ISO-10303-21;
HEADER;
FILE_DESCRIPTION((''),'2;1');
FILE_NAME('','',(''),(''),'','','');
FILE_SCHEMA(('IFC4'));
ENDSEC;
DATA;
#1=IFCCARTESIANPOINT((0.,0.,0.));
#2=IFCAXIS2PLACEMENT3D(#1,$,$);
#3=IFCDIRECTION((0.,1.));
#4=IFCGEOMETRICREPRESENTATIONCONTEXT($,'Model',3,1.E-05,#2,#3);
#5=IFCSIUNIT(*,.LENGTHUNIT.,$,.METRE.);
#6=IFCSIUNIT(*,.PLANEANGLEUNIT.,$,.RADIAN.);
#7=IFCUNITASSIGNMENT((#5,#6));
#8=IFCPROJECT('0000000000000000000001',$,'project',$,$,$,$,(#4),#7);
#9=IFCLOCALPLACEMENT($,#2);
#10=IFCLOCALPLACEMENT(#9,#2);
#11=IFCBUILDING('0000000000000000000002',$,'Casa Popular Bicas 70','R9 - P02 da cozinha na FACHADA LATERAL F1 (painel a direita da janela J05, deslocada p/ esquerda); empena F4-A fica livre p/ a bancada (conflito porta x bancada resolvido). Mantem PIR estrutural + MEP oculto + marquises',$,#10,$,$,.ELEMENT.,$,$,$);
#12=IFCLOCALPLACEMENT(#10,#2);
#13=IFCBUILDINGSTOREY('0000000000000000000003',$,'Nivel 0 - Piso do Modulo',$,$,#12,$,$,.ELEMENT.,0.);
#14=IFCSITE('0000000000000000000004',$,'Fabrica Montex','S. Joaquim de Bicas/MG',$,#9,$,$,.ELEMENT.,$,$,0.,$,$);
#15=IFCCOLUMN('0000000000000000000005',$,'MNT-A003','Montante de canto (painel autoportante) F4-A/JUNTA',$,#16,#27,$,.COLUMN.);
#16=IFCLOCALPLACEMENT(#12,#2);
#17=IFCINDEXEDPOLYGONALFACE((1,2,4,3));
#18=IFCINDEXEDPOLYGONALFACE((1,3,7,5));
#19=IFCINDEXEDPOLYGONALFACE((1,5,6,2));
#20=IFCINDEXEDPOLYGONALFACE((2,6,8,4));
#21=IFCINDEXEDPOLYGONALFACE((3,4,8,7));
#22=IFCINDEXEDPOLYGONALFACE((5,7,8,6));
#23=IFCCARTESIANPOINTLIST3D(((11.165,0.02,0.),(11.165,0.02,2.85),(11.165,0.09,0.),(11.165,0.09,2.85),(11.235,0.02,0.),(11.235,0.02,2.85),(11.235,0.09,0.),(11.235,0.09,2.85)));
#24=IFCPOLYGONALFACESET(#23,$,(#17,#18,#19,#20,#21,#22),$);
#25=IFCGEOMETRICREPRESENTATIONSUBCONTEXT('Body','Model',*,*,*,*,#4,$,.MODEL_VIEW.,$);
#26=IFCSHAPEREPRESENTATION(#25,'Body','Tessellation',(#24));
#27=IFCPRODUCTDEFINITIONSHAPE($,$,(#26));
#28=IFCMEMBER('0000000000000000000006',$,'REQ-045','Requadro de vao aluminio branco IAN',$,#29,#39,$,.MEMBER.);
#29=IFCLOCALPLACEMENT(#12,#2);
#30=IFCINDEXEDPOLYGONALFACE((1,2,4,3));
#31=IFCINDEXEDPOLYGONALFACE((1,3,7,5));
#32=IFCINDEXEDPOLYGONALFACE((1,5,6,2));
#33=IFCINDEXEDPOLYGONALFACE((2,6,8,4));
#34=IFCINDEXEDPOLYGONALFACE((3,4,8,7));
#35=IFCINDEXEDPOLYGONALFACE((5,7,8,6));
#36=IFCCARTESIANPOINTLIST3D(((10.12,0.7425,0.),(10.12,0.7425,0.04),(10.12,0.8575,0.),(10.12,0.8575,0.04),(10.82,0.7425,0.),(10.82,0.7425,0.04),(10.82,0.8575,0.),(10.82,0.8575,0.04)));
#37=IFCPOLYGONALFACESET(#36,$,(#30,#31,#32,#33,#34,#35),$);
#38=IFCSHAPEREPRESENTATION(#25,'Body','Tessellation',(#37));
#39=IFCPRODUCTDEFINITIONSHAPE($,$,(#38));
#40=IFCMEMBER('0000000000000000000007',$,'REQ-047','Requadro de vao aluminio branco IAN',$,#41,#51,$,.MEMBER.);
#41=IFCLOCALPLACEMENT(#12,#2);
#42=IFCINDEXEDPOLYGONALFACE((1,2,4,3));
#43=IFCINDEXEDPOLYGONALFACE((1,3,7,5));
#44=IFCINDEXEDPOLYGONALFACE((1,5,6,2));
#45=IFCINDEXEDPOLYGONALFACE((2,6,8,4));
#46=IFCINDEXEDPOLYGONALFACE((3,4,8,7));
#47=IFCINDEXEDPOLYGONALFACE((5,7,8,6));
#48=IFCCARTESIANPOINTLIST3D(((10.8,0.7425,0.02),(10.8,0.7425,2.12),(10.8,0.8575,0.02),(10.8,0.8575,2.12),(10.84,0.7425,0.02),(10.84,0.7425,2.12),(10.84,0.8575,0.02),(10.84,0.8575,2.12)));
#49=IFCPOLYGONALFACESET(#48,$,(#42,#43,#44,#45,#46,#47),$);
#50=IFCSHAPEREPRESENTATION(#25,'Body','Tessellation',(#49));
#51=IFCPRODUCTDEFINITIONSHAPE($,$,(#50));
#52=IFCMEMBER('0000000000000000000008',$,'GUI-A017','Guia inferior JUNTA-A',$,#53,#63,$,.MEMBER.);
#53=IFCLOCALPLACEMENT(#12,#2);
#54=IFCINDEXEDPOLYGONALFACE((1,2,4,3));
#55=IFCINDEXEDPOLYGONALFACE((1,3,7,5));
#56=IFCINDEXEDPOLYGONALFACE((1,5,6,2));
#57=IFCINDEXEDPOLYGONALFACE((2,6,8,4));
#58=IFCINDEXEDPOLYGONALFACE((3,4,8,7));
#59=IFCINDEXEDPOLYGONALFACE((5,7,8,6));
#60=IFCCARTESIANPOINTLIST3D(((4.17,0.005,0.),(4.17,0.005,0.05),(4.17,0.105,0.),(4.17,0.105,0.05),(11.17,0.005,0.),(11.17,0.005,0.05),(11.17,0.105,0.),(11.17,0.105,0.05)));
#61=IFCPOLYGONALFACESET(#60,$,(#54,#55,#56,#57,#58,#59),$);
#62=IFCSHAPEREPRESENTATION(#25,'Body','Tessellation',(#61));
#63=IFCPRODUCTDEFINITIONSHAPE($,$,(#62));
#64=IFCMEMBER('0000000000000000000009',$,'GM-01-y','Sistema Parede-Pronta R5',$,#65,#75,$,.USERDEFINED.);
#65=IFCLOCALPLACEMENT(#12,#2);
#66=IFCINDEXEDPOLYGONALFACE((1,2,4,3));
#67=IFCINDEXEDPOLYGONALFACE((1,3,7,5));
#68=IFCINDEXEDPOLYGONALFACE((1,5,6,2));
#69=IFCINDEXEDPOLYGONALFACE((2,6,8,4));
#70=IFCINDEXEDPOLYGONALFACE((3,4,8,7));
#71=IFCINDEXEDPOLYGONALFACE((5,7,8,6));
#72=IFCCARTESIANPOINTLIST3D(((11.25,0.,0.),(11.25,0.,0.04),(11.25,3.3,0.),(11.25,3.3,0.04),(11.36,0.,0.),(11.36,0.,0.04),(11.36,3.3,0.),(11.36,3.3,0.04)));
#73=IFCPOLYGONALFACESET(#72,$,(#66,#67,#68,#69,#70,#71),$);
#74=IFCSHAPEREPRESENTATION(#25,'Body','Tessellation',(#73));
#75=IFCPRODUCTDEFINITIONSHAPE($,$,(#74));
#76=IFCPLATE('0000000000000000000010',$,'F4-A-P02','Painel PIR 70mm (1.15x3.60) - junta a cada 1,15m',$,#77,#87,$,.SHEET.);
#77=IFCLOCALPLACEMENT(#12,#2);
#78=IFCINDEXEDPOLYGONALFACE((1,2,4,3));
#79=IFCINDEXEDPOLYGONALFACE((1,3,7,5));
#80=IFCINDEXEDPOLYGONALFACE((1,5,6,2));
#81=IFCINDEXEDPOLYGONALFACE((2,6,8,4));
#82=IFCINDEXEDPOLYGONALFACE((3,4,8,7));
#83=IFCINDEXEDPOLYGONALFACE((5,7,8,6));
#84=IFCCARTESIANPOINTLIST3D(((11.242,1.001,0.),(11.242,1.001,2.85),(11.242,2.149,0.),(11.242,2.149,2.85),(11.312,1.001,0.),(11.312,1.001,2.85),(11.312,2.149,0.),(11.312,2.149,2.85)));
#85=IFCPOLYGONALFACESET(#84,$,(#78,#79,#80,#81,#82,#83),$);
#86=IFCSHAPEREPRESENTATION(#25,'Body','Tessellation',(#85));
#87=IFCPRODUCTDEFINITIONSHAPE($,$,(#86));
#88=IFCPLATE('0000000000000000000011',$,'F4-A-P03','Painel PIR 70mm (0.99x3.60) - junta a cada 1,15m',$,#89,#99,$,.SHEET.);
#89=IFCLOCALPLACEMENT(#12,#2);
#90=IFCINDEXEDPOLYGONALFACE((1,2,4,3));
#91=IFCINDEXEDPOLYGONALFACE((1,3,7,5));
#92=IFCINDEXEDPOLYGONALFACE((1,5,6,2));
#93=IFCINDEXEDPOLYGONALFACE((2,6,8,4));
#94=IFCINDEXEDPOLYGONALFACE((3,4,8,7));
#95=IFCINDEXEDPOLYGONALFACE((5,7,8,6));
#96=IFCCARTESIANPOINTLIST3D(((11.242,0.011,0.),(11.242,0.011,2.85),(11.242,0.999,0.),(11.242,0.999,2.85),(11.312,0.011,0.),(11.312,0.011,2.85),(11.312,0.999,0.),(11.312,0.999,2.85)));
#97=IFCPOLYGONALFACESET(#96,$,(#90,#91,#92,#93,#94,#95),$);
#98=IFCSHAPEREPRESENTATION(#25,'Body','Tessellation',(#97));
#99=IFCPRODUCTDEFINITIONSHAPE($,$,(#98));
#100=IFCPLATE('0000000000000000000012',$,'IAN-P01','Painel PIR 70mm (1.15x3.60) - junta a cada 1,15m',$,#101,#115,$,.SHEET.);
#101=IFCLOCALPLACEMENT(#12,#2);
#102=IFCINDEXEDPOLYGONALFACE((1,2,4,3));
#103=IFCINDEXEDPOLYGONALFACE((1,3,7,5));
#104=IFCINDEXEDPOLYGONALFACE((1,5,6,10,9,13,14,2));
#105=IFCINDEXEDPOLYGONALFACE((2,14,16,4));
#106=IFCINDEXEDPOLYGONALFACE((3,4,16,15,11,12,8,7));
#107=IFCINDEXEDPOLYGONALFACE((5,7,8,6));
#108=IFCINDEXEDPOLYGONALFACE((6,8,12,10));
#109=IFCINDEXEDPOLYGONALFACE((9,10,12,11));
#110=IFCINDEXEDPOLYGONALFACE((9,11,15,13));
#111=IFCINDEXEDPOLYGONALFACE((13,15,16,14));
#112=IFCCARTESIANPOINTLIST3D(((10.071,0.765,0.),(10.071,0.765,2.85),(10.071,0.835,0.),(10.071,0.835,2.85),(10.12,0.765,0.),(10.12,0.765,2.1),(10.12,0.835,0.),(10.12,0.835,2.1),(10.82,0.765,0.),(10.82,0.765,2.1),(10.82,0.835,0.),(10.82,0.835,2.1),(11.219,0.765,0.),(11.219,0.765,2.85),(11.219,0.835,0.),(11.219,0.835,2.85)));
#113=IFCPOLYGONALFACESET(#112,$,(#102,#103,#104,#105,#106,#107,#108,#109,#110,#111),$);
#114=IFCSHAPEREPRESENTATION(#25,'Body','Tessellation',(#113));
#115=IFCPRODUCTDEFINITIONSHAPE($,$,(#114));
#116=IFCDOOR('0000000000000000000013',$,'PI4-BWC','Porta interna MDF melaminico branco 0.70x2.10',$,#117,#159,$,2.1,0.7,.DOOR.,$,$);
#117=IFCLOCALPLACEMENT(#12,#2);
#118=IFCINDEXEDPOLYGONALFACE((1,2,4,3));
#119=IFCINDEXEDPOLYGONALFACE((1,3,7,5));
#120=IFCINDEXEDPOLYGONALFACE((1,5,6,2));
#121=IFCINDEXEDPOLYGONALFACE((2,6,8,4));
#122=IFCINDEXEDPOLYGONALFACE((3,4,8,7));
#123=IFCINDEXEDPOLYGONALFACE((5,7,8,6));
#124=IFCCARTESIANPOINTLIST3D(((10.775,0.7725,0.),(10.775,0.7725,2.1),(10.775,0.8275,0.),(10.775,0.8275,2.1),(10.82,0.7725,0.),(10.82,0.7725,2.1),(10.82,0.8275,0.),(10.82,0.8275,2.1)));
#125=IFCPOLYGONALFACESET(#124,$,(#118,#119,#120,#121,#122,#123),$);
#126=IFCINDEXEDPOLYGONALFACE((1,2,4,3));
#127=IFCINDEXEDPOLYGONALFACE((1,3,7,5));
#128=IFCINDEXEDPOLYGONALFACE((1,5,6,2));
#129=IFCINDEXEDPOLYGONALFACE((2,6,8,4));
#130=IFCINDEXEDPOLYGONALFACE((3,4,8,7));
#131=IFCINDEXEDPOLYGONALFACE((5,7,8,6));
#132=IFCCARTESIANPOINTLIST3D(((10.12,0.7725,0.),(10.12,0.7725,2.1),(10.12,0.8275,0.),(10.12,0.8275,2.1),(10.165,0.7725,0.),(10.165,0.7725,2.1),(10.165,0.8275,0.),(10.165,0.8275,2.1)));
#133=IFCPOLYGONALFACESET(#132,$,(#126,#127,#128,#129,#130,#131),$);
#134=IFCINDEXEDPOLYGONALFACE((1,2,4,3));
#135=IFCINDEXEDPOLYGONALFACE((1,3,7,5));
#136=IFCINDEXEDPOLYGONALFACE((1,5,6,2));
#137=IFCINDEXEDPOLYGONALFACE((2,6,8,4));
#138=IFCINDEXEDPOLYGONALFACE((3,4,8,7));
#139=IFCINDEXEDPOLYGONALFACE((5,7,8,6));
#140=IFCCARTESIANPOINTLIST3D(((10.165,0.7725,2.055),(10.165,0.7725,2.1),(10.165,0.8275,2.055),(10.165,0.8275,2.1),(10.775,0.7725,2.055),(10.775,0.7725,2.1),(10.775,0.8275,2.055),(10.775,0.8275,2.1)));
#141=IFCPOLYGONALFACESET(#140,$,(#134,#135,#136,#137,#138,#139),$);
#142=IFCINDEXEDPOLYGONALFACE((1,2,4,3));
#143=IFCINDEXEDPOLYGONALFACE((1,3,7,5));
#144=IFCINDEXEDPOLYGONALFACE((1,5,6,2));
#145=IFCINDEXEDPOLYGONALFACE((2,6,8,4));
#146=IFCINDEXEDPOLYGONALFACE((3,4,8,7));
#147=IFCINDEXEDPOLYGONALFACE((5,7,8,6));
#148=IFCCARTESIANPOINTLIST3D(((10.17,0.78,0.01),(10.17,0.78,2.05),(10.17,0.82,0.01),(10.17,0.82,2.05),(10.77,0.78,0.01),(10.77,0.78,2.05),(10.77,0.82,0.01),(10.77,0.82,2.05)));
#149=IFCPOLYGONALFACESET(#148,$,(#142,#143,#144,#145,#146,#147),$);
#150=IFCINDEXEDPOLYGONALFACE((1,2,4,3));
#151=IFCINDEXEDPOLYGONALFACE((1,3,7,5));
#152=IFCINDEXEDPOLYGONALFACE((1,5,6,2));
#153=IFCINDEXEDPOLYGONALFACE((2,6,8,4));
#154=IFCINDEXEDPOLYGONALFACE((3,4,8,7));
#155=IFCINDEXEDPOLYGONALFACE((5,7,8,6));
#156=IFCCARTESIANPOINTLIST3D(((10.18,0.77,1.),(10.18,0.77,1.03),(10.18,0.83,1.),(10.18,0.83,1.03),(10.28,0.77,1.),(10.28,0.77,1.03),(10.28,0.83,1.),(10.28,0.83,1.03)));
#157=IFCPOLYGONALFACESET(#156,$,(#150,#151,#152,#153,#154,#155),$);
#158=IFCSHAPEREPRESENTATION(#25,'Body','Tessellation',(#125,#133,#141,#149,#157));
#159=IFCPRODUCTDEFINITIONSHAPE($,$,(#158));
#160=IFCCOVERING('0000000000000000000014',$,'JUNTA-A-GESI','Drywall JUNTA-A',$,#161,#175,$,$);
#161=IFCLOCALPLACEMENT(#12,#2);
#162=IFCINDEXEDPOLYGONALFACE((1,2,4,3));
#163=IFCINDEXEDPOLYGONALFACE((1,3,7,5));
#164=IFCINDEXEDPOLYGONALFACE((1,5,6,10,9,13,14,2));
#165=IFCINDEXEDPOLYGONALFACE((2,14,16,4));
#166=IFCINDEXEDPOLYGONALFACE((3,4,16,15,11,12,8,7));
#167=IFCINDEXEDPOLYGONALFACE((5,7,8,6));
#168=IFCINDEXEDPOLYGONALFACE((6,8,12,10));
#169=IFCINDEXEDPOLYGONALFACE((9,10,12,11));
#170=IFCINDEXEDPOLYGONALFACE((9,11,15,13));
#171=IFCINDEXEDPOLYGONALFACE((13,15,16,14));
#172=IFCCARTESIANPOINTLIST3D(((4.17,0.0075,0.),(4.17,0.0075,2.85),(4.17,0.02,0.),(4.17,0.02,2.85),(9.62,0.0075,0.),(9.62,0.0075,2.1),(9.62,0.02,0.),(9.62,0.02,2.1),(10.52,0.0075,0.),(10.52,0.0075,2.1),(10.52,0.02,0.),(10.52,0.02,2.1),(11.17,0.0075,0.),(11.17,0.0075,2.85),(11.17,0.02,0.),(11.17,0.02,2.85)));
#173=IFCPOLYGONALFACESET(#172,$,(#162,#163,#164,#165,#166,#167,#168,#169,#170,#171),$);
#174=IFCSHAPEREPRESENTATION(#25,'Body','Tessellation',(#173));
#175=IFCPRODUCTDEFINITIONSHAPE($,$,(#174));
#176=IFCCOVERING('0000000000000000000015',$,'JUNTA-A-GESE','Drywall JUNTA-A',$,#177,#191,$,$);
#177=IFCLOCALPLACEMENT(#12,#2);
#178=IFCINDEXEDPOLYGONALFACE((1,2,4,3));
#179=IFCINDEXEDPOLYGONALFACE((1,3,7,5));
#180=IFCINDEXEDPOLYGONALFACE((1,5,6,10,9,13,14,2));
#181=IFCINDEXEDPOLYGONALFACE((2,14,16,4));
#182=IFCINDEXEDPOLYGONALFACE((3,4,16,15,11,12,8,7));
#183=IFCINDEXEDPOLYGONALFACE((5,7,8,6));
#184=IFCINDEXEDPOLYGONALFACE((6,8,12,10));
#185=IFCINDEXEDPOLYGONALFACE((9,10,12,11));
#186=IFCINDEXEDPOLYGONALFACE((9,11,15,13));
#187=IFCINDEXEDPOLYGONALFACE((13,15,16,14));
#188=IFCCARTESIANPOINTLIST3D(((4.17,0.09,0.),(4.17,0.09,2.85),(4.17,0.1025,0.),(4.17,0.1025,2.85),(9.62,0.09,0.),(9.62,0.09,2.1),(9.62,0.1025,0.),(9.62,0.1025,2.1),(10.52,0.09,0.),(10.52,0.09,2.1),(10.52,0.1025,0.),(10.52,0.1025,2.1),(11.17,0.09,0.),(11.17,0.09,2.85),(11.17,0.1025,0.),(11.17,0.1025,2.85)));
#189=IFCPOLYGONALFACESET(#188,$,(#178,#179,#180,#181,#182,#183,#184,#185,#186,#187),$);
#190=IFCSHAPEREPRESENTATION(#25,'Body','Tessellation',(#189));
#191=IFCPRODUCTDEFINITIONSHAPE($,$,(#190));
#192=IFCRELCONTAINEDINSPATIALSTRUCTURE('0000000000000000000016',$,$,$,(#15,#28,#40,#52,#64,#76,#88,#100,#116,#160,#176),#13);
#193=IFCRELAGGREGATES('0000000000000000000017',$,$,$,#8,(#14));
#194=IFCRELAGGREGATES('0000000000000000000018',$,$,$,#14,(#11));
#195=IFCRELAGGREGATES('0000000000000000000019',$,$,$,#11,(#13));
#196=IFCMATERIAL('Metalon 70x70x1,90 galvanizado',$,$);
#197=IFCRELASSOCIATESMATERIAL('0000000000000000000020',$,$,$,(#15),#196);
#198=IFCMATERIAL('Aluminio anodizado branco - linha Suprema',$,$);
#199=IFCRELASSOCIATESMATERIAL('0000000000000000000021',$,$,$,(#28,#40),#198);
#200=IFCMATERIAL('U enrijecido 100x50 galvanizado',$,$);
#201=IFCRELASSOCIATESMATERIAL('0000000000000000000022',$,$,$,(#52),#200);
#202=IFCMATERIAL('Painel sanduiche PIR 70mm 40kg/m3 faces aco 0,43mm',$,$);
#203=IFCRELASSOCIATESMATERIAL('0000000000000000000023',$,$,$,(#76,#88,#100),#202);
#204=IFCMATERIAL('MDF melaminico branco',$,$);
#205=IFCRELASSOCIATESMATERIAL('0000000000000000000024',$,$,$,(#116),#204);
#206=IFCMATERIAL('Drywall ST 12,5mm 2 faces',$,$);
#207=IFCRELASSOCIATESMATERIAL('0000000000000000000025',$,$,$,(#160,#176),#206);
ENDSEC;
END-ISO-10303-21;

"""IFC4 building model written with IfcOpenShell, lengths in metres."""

from ifc_helpers import new_model, si_unit, direction, frame, frame_2d, origin, origin_2d, place, context, subcontext, project, spatial, rectangle, extrude, material, element, fill, save


model = new_model("IFC4")

# Units and contexts
model_context = context("Model", 3, precision=1e-05, world=origin(), true_north=direction((0.0, 1.0)))
body_context = subcontext(model_context, "Body", "Model", "MODEL_VIEW")
ifc_project = project(units=[si_unit("LENGTHUNIT", "METRE"), si_unit("PLANEANGLEUNIT", "RADIAN")], contexts=[model_context])

# Site, building, storey
site_placement = place(None, origin())
site = spatial("IfcSite", under=ifc_project, at=site_placement, Name="Fabrica Montex", Description="S. Joaquim de Bicas/MG", CompositionType="ELEMENT", RefElevation=0.0)
building_placement = place(site_placement, origin())
building = spatial("IfcBuilding", under=site, at=building_placement, Name="Casa Popular Bicas 70", Description="R9 - P02 da cozinha na FACHADA LATERAL F1 (painel a direita da janela J05, deslocada p/ esquerda); empena F4-A fica livre p/ a bancada (conflito porta x bancada resolvido). Mantem PIR estrutural + MEP oculto + marquises", CompositionType="ELEMENT")
storey_placement = place(building_placement, origin())
storey = spatial("IfcBuildingStorey", under=building, at=storey_placement, Name="Nivel 0 - Piso do Modulo", CompositionType="ELEMENT", Elevation=0.0)

# Column
ifc_material_1 = material(Name="Metalon 70x70x1,90 galvanizado")
column_placement = place(None, frame((11.2, 0.055, 0.0), z_axis=(0.0, 0.0, 1.0), x_axis=(-1.0, 0.0, 0.0)))
element("IfcColumn", 1, at=column_placement, inside=storey, material=ifc_material_1, Name="MNT-A003", Description="Montante de canto (painel autoportante) F4-A/JUNTA", PredefinedType="COLUMN", context=body_context, shape_type="SweptSolid", body=[
    extrude(rectangle(XDim=0.07, YDim=0.07, at=origin_2d()), origin(), (0.0, 0.0, 1.0), 2.85),
])

# Members
ifc_material_2 = material(Name="Aluminio anodizado branco - linha Suprema")
member_1_placement = place(None, frame((10.82, 0.8, 0.02), z_axis=(-1.0, 0.0, 0.0), x_axis=(0.0, 0.0, 1.0)))
element("IfcMember", 2, at=member_1_placement, inside=storey, material=ifc_material_2, Name="REQ-045", Description="Requadro de vao aluminio branco IAN", PredefinedType="MEMBER", context=body_context, shape_type="SweptSolid", body=[
    extrude(rectangle(XDim=0.04, YDim=0.115, at=origin_2d()), origin(), (0.0, 0.0, 1.0), 0.7),
])
member_2_placement = place(None, frame((10.82, 0.8, 0.02), z_axis=(0.0, 0.0, 1.0), x_axis=(-1.0, 0.0, 0.0)))
element("IfcMember", 3, at=member_2_placement, inside=storey, material=ifc_material_2, Name="REQ-047", Description="Requadro de vao aluminio branco IAN", PredefinedType="MEMBER", context=body_context, shape_type="SweptSolid", body=[
    extrude(rectangle(XDim=0.04, YDim=0.115, at=origin_2d()), origin(), (0.0, 0.0, 1.0), 2.1),
])
ifc_material_3 = material(Name="U enrijecido 100x50 galvanizado")
member_3_placement = place(None, frame((11.17, 0.055, 0.025), z_axis=(-1.0, 0.0, 0.0), x_axis=(0.0, 0.0, 1.0)))
element("IfcMember", 4, at=member_3_placement, inside=storey, material=ifc_material_3, Name="GUI-A017", Description="Guia inferior JUNTA-A", PredefinedType="MEMBER", context=body_context, shape_type="SweptSolid", body=[
    extrude(rectangle(XDim=0.05, YDim=0.1, at=origin_2d()), origin(), (0.0, 0.0, 1.0), 7.0),
])
member_4_placement = place(storey_placement, frame((11.305, 1.65, 0.0)))
element("IfcMember", 5, at=member_4_placement, inside=storey, Name="GM-01-y", Description="Sistema Parede-Pronta R5", PredefinedType="USERDEFINED", context=body_context, shape_type="SweptSolid", body=[
    extrude(rectangle(XDim=0.11, YDim=3.3, at=origin_2d()), origin(), (0.0, 0.0, 1.0), 0.04),
])

# Plates
ifc_material_4 = material(Name="Painel sanduiche PIR 70mm 40kg/m3 faces aco 0,43mm")
plate_1_placement = place(None, frame((11.277, 2.149, 0.0), z_axis=(0.0, 0.0, 1.0), x_axis=(0.0, -1.0, 0.0)))
element("IfcPlate", 6, at=plate_1_placement, inside=storey, material=ifc_material_4, Name="F4-A-P02", Description="Painel PIR 70mm (1.15x3.60) - junta a cada 1,15m", PredefinedType="SHEET", context=body_context, shape_type="SweptSolid", body=[
    extrude(rectangle(XDim=1.148, YDim=0.07, at=frame_2d((0.574, 0.0))), origin(), (0.0, 0.0, 1.0), 2.85),
])
plate_2_placement = place(None, frame((11.277, 0.999, 0.0), z_axis=(0.0, 0.0, 1.0), x_axis=(0.0, -1.0, 0.0)))
element("IfcPlate", 7, at=plate_2_placement, inside=storey, material=ifc_material_4, Name="F4-A-P03", Description="Painel PIR 70mm (0.99x3.60) - junta a cada 1,15m", PredefinedType="SHEET", context=body_context, shape_type="SweptSolid", body=[
    extrude(rectangle(XDim=0.988, YDim=0.07, at=frame_2d((0.494, 0.0))), origin(), (0.0, 0.0, 1.0), 2.85),
])

# Plate, opening, door
plate_3_placement = place(None, frame((11.219, 0.8, 0.0), z_axis=(0.0, 0.0, 1.0), x_axis=(-1.0, 0.0, 0.0)))
plate_3 = element("IfcPlate", 8, at=plate_3_placement, inside=storey, material=ifc_material_4, Name="IAN-P01", Description="Painel PIR 70mm (1.15x3.60) - junta a cada 1,15m", PredefinedType="SHEET", context=body_context, shape_type="SweptSolid", body=[
    extrude(rectangle(XDim=1.148, YDim=0.07, at=frame_2d((0.574, 0.0))), origin(), (0.0, 0.0, 1.0), 2.85),
])
opening_1_placement = place(None, frame((10.47, 0.8, 0.0), z_axis=(0.0, 0.0, 1.0), x_axis=(-1.0, 0.0, 0.0)))
opening_1 = element("IfcOpeningElement", 9, at=opening_1_placement, cuts=plate_3, PredefinedType="OPENING", context=body_context, shape_type="SweptSolid", body=[
    extrude(rectangle(XDim=0.7, YDim=0.1, at=origin_2d()), origin(), (0.0, 0.0, 1.0), 2.1),
])
ifc_material_5 = material(Name="MDF melaminico branco")
door_placement = place(None, frame((10.82, 0.8, 0.0), z_axis=(0.0, 0.0, 1.0), x_axis=(-1.0, 0.0, 0.0)))
door = element("IfcDoor", 10, at=door_placement, inside=storey, material=ifc_material_5, Name="PI4-BWC", Description="Porta interna MDF melaminico branco 0.70x2.10", OverallHeight=2.1, OverallWidth=0.7, PredefinedType="DOOR", context=body_context, shape_type="SweptSolid", body=[
    extrude(rectangle(XDim=0.045, YDim=0.055, at=frame_2d((0.0225, 0.0))), origin(), (0.0, 0.0, 1.0), 2.1),
    extrude(rectangle(XDim=0.045, YDim=0.055, at=frame_2d((0.6775, 0.0))), origin(), (0.0, 0.0, 1.0), 2.1),
    extrude(rectangle(XDim=0.61, YDim=0.055, at=frame_2d((0.35, 0.0))), frame((0.0, 0.0, 2.055)), (0.0, 0.0, 1.0), 0.045),
    extrude(rectangle(XDim=0.6, YDim=0.04, at=frame_2d((0.35, 0.0))), frame((0.0, 0.0, 0.01)), (0.0, 0.0, 1.0), 2.04),
    extrude(rectangle(XDim=0.1, YDim=0.06, at=frame_2d((0.59, 0.0))), frame((0.0, 0.0, 1.0)), (0.0, 0.0, 1.0), 0.03),
])
fill(opening_1, door)

# Coverings, openings
ifc_material_6 = material(Name="Drywall ST 12,5mm 2 faces")
covering_1_placement = place(None, frame((11.17, 0.0137, 0.0), z_axis=(0.0, 0.0, 1.0), x_axis=(-1.0, 0.0, 0.0)))
covering_1 = element("IfcCovering", 11, at=covering_1_placement, inside=storey, material=ifc_material_6, Name="JUNTA-A-GESI", Description="Drywall JUNTA-A", context=body_context, shape_type="SweptSolid", body=[
    extrude(rectangle(XDim=7.0, YDim=0.0125, at=frame_2d((3.5, 0.0))), origin(), (0.0, 0.0, 1.0), 2.85),
])
opening_2_placement = place(None, frame((10.07, 0.0137, 0.0), z_axis=(0.0, 0.0, 1.0), x_axis=(-1.0, 0.0, 0.0)))
element("IfcOpeningElement", 12, at=opening_2_placement, cuts=covering_1, PredefinedType="OPENING", context=body_context, shape_type="SweptSolid", body=[
    extrude(rectangle(XDim=0.9, YDim=0.0425, at=origin_2d()), origin(), (0.0, 0.0, 1.0), 2.1),
])
covering_2_placement = place(None, frame((11.17, 0.0962, 0.0), z_axis=(0.0, 0.0, 1.0), x_axis=(-1.0, 0.0, 0.0)))
covering_2 = element("IfcCovering", 13, at=covering_2_placement, inside=storey, material=ifc_material_6, Name="JUNTA-A-GESE", Description="Drywall JUNTA-A", context=body_context, shape_type="SweptSolid", body=[
    extrude(rectangle(XDim=7.0, YDim=0.0125, at=frame_2d((3.5, 0.0))), origin(), (0.0, 0.0, 1.0), 2.85),
])
opening_3_placement = place(None, frame((10.07, 0.0962, 0.0), z_axis=(0.0, 0.0, 1.0), x_axis=(-1.0, 0.0, 0.0)))
element("IfcOpeningElement", 14, at=opening_3_placement, cuts=covering_2, PredefinedType="OPENING", context=body_context, shape_type="SweptSolid", body=[
    extrude(rectangle(XDim=0.9, YDim=0.0425, at=origin_2d()), origin(), (0.0, 0.0, 1.0), 2.1),
])

save(model, "model.ifc")
